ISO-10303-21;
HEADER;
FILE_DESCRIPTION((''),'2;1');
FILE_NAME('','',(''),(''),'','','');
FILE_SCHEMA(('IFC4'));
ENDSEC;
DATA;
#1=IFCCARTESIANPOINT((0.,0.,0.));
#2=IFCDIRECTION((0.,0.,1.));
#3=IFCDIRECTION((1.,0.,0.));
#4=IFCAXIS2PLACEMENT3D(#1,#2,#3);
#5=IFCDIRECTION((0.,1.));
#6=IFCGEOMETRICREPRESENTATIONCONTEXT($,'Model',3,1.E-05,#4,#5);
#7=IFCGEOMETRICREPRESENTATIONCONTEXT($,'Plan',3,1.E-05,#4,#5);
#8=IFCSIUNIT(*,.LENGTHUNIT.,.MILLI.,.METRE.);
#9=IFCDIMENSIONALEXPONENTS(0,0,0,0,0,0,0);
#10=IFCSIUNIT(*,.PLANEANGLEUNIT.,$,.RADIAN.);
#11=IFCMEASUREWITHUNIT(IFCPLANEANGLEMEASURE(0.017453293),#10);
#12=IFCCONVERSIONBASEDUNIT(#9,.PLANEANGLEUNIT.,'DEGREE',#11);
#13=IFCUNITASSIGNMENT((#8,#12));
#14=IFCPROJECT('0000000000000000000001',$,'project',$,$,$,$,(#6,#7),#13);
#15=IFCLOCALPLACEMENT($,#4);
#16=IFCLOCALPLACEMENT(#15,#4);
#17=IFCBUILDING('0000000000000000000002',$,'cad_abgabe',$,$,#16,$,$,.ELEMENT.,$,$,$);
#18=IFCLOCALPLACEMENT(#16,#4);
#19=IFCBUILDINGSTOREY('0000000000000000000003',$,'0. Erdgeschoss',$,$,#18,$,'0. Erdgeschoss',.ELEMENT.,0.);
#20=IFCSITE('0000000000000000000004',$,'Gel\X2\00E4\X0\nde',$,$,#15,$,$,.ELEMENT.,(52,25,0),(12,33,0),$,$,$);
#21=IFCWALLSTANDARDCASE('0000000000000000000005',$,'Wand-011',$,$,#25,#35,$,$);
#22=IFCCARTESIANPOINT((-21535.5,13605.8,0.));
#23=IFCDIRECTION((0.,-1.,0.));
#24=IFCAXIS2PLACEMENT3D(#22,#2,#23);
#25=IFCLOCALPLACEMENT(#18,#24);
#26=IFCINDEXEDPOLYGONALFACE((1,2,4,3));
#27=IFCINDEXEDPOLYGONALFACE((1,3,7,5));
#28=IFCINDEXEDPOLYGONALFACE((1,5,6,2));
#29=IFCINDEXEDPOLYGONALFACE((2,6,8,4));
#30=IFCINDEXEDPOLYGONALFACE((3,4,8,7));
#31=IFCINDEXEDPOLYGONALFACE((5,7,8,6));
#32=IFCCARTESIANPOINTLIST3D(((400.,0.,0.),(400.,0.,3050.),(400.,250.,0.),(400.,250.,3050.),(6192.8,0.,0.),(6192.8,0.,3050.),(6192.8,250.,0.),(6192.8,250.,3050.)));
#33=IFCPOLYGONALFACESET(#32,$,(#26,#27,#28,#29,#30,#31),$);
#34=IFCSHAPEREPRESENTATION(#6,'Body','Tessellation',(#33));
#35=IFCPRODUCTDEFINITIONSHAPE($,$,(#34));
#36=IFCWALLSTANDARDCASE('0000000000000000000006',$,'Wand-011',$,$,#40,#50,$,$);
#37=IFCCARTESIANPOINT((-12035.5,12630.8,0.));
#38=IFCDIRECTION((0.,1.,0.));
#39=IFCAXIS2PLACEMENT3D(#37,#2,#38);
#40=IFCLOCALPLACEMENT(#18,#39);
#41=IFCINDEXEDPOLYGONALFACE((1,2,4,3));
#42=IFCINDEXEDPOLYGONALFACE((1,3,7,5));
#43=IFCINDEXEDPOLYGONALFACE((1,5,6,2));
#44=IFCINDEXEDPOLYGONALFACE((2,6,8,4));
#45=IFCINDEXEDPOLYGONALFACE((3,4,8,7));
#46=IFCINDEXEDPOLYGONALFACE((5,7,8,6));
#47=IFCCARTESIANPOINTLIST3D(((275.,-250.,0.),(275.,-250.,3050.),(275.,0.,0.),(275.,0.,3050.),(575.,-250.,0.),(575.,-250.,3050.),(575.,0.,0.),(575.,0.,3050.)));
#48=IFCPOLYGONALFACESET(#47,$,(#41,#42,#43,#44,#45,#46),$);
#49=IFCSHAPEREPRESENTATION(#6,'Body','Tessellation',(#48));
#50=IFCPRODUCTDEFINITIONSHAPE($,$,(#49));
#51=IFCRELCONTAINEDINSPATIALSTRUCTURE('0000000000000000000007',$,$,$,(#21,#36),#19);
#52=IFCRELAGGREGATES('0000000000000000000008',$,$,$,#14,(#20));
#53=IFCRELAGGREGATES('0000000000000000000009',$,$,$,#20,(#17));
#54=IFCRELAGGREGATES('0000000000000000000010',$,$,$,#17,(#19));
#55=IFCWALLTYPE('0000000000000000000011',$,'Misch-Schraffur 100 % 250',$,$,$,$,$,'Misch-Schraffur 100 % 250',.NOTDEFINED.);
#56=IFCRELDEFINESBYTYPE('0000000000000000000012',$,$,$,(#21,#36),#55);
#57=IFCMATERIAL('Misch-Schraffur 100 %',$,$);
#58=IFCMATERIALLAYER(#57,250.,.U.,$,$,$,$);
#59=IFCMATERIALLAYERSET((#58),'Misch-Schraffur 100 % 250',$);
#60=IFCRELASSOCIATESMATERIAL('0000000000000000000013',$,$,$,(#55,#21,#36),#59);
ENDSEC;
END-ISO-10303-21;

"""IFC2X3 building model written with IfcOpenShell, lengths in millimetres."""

from ifc_helpers import new_model, entity, si_unit, converted_unit, direction, frame, origin_with_axes, place, context, project, spatial, polyline, outline, extrude, material, layer, layer_set, layer_usage, type_object, element, save


model = new_model("IFC2X3")

# Units and contexts
model_context = context("Model", 3, precision=1e-05, world=origin_with_axes(), true_north=direction((0.0, 1.0)))
plan_context = context("Plan", 3, precision=1e-05, world=origin_with_axes(), true_north=direction((0.0, 1.0)))
ifc_project = project(units=[si_unit("LENGTHUNIT", "METRE", prefix="MILLI"), converted_unit("PLANEANGLEUNIT", "DEGREE", entity("IfcPlaneAngleMeasure", 0.017453293), si_unit("PLANEANGLEUNIT", "RADIAN"), dimensions=[0, 0, 0, 0, 0, 0, 0])], contexts=[model_context, plan_context])

# Site, building, storey
site_placement = place(None, origin_with_axes())
site = spatial("IfcSite", under=ifc_project, at=site_placement, Name="Gelände", CompositionType="ELEMENT", RefLatitude=(52, 25, 0), RefLongitude=(12, 33, 0))
building_placement = place(site_placement, origin_with_axes())
building = spatial("IfcBuilding", under=site, at=building_placement, Name="cad_abgabe", CompositionType="ELEMENT")
storey_placement = place(building_placement, origin_with_axes())
storey = spatial("IfcBuildingStorey", under=building, at=storey_placement, Name="0. Erdgeschoss", LongName="0. Erdgeschoss", CompositionType="ELEMENT", Elevation=0.0)

# Shared definitions
ifc_material = material(Name="Misch-Schraffur 100 %")

# Walls
ifc_layer_1 = layer(ifc_material, 250.0, ventilated="UNKNOWN")
ifc_layer_set_1 = layer_set([ifc_layer_1], Name="Misch-Schraffur 100 % 250")
ifc_layer_usage_1 = layer_usage(ifc_layer_set_1, "AXIS2", "POSITIVE", 0.0)
wall_type_1 = type_object("IfcWallType", Name="Misch-Schraffur 100 % 250", ElementType="Misch-Schraffur 100 % 250", PredefinedType="NOTDEFINED", material=ifc_layer_set_1)
wall_1_placement = place(storey_placement, frame((-21535.5, 13605.8, 0.0), z_axis=(0.0, 0.0, 1.0), x_axis=(0.0, -1.0, 0.0)))
element("IfcWallStandardCase", 1, at=wall_1_placement, inside=storey, type_object=wall_type_1, material=ifc_layer_usage_1, Name="Wand-011", context=model_context, shape_type="SweptSolid", body=[
    extrude(outline(polyline([(400.0, 0.0), (6192.8, 0.0), (6192.8, 250.0), (400.0, 250.0), (400.0, 0.0)])), origin_with_axes(), (0.0, 0.0, 1.0), 3050.0),
])
ifc_layer_usage_2 = layer_usage(ifc_layer_set_1, "AXIS2", "NEGATIVE", 0.0)
wall_2_placement = place(storey_placement, frame((-12035.5, 12630.8, 0.0), z_axis=(0.0, 0.0, 1.0), x_axis=(0.0, 1.0, 0.0)))
element("IfcWallStandardCase", 2, at=wall_2_placement, inside=storey, type_object=wall_type_1, material=ifc_layer_usage_2, Name="Wand-011", context=model_context, shape_type="SweptSolid", body=[
    extrude(outline(polyline([(275.0, -250.0), (575.0, -250.0), (575.0, 0.0), (275.0, 0.0), (275.0, -250.0)])), origin_with_axes(), (0.0, 0.0, 1.0), 3050.0),
])

save(model, "model.ifc")
